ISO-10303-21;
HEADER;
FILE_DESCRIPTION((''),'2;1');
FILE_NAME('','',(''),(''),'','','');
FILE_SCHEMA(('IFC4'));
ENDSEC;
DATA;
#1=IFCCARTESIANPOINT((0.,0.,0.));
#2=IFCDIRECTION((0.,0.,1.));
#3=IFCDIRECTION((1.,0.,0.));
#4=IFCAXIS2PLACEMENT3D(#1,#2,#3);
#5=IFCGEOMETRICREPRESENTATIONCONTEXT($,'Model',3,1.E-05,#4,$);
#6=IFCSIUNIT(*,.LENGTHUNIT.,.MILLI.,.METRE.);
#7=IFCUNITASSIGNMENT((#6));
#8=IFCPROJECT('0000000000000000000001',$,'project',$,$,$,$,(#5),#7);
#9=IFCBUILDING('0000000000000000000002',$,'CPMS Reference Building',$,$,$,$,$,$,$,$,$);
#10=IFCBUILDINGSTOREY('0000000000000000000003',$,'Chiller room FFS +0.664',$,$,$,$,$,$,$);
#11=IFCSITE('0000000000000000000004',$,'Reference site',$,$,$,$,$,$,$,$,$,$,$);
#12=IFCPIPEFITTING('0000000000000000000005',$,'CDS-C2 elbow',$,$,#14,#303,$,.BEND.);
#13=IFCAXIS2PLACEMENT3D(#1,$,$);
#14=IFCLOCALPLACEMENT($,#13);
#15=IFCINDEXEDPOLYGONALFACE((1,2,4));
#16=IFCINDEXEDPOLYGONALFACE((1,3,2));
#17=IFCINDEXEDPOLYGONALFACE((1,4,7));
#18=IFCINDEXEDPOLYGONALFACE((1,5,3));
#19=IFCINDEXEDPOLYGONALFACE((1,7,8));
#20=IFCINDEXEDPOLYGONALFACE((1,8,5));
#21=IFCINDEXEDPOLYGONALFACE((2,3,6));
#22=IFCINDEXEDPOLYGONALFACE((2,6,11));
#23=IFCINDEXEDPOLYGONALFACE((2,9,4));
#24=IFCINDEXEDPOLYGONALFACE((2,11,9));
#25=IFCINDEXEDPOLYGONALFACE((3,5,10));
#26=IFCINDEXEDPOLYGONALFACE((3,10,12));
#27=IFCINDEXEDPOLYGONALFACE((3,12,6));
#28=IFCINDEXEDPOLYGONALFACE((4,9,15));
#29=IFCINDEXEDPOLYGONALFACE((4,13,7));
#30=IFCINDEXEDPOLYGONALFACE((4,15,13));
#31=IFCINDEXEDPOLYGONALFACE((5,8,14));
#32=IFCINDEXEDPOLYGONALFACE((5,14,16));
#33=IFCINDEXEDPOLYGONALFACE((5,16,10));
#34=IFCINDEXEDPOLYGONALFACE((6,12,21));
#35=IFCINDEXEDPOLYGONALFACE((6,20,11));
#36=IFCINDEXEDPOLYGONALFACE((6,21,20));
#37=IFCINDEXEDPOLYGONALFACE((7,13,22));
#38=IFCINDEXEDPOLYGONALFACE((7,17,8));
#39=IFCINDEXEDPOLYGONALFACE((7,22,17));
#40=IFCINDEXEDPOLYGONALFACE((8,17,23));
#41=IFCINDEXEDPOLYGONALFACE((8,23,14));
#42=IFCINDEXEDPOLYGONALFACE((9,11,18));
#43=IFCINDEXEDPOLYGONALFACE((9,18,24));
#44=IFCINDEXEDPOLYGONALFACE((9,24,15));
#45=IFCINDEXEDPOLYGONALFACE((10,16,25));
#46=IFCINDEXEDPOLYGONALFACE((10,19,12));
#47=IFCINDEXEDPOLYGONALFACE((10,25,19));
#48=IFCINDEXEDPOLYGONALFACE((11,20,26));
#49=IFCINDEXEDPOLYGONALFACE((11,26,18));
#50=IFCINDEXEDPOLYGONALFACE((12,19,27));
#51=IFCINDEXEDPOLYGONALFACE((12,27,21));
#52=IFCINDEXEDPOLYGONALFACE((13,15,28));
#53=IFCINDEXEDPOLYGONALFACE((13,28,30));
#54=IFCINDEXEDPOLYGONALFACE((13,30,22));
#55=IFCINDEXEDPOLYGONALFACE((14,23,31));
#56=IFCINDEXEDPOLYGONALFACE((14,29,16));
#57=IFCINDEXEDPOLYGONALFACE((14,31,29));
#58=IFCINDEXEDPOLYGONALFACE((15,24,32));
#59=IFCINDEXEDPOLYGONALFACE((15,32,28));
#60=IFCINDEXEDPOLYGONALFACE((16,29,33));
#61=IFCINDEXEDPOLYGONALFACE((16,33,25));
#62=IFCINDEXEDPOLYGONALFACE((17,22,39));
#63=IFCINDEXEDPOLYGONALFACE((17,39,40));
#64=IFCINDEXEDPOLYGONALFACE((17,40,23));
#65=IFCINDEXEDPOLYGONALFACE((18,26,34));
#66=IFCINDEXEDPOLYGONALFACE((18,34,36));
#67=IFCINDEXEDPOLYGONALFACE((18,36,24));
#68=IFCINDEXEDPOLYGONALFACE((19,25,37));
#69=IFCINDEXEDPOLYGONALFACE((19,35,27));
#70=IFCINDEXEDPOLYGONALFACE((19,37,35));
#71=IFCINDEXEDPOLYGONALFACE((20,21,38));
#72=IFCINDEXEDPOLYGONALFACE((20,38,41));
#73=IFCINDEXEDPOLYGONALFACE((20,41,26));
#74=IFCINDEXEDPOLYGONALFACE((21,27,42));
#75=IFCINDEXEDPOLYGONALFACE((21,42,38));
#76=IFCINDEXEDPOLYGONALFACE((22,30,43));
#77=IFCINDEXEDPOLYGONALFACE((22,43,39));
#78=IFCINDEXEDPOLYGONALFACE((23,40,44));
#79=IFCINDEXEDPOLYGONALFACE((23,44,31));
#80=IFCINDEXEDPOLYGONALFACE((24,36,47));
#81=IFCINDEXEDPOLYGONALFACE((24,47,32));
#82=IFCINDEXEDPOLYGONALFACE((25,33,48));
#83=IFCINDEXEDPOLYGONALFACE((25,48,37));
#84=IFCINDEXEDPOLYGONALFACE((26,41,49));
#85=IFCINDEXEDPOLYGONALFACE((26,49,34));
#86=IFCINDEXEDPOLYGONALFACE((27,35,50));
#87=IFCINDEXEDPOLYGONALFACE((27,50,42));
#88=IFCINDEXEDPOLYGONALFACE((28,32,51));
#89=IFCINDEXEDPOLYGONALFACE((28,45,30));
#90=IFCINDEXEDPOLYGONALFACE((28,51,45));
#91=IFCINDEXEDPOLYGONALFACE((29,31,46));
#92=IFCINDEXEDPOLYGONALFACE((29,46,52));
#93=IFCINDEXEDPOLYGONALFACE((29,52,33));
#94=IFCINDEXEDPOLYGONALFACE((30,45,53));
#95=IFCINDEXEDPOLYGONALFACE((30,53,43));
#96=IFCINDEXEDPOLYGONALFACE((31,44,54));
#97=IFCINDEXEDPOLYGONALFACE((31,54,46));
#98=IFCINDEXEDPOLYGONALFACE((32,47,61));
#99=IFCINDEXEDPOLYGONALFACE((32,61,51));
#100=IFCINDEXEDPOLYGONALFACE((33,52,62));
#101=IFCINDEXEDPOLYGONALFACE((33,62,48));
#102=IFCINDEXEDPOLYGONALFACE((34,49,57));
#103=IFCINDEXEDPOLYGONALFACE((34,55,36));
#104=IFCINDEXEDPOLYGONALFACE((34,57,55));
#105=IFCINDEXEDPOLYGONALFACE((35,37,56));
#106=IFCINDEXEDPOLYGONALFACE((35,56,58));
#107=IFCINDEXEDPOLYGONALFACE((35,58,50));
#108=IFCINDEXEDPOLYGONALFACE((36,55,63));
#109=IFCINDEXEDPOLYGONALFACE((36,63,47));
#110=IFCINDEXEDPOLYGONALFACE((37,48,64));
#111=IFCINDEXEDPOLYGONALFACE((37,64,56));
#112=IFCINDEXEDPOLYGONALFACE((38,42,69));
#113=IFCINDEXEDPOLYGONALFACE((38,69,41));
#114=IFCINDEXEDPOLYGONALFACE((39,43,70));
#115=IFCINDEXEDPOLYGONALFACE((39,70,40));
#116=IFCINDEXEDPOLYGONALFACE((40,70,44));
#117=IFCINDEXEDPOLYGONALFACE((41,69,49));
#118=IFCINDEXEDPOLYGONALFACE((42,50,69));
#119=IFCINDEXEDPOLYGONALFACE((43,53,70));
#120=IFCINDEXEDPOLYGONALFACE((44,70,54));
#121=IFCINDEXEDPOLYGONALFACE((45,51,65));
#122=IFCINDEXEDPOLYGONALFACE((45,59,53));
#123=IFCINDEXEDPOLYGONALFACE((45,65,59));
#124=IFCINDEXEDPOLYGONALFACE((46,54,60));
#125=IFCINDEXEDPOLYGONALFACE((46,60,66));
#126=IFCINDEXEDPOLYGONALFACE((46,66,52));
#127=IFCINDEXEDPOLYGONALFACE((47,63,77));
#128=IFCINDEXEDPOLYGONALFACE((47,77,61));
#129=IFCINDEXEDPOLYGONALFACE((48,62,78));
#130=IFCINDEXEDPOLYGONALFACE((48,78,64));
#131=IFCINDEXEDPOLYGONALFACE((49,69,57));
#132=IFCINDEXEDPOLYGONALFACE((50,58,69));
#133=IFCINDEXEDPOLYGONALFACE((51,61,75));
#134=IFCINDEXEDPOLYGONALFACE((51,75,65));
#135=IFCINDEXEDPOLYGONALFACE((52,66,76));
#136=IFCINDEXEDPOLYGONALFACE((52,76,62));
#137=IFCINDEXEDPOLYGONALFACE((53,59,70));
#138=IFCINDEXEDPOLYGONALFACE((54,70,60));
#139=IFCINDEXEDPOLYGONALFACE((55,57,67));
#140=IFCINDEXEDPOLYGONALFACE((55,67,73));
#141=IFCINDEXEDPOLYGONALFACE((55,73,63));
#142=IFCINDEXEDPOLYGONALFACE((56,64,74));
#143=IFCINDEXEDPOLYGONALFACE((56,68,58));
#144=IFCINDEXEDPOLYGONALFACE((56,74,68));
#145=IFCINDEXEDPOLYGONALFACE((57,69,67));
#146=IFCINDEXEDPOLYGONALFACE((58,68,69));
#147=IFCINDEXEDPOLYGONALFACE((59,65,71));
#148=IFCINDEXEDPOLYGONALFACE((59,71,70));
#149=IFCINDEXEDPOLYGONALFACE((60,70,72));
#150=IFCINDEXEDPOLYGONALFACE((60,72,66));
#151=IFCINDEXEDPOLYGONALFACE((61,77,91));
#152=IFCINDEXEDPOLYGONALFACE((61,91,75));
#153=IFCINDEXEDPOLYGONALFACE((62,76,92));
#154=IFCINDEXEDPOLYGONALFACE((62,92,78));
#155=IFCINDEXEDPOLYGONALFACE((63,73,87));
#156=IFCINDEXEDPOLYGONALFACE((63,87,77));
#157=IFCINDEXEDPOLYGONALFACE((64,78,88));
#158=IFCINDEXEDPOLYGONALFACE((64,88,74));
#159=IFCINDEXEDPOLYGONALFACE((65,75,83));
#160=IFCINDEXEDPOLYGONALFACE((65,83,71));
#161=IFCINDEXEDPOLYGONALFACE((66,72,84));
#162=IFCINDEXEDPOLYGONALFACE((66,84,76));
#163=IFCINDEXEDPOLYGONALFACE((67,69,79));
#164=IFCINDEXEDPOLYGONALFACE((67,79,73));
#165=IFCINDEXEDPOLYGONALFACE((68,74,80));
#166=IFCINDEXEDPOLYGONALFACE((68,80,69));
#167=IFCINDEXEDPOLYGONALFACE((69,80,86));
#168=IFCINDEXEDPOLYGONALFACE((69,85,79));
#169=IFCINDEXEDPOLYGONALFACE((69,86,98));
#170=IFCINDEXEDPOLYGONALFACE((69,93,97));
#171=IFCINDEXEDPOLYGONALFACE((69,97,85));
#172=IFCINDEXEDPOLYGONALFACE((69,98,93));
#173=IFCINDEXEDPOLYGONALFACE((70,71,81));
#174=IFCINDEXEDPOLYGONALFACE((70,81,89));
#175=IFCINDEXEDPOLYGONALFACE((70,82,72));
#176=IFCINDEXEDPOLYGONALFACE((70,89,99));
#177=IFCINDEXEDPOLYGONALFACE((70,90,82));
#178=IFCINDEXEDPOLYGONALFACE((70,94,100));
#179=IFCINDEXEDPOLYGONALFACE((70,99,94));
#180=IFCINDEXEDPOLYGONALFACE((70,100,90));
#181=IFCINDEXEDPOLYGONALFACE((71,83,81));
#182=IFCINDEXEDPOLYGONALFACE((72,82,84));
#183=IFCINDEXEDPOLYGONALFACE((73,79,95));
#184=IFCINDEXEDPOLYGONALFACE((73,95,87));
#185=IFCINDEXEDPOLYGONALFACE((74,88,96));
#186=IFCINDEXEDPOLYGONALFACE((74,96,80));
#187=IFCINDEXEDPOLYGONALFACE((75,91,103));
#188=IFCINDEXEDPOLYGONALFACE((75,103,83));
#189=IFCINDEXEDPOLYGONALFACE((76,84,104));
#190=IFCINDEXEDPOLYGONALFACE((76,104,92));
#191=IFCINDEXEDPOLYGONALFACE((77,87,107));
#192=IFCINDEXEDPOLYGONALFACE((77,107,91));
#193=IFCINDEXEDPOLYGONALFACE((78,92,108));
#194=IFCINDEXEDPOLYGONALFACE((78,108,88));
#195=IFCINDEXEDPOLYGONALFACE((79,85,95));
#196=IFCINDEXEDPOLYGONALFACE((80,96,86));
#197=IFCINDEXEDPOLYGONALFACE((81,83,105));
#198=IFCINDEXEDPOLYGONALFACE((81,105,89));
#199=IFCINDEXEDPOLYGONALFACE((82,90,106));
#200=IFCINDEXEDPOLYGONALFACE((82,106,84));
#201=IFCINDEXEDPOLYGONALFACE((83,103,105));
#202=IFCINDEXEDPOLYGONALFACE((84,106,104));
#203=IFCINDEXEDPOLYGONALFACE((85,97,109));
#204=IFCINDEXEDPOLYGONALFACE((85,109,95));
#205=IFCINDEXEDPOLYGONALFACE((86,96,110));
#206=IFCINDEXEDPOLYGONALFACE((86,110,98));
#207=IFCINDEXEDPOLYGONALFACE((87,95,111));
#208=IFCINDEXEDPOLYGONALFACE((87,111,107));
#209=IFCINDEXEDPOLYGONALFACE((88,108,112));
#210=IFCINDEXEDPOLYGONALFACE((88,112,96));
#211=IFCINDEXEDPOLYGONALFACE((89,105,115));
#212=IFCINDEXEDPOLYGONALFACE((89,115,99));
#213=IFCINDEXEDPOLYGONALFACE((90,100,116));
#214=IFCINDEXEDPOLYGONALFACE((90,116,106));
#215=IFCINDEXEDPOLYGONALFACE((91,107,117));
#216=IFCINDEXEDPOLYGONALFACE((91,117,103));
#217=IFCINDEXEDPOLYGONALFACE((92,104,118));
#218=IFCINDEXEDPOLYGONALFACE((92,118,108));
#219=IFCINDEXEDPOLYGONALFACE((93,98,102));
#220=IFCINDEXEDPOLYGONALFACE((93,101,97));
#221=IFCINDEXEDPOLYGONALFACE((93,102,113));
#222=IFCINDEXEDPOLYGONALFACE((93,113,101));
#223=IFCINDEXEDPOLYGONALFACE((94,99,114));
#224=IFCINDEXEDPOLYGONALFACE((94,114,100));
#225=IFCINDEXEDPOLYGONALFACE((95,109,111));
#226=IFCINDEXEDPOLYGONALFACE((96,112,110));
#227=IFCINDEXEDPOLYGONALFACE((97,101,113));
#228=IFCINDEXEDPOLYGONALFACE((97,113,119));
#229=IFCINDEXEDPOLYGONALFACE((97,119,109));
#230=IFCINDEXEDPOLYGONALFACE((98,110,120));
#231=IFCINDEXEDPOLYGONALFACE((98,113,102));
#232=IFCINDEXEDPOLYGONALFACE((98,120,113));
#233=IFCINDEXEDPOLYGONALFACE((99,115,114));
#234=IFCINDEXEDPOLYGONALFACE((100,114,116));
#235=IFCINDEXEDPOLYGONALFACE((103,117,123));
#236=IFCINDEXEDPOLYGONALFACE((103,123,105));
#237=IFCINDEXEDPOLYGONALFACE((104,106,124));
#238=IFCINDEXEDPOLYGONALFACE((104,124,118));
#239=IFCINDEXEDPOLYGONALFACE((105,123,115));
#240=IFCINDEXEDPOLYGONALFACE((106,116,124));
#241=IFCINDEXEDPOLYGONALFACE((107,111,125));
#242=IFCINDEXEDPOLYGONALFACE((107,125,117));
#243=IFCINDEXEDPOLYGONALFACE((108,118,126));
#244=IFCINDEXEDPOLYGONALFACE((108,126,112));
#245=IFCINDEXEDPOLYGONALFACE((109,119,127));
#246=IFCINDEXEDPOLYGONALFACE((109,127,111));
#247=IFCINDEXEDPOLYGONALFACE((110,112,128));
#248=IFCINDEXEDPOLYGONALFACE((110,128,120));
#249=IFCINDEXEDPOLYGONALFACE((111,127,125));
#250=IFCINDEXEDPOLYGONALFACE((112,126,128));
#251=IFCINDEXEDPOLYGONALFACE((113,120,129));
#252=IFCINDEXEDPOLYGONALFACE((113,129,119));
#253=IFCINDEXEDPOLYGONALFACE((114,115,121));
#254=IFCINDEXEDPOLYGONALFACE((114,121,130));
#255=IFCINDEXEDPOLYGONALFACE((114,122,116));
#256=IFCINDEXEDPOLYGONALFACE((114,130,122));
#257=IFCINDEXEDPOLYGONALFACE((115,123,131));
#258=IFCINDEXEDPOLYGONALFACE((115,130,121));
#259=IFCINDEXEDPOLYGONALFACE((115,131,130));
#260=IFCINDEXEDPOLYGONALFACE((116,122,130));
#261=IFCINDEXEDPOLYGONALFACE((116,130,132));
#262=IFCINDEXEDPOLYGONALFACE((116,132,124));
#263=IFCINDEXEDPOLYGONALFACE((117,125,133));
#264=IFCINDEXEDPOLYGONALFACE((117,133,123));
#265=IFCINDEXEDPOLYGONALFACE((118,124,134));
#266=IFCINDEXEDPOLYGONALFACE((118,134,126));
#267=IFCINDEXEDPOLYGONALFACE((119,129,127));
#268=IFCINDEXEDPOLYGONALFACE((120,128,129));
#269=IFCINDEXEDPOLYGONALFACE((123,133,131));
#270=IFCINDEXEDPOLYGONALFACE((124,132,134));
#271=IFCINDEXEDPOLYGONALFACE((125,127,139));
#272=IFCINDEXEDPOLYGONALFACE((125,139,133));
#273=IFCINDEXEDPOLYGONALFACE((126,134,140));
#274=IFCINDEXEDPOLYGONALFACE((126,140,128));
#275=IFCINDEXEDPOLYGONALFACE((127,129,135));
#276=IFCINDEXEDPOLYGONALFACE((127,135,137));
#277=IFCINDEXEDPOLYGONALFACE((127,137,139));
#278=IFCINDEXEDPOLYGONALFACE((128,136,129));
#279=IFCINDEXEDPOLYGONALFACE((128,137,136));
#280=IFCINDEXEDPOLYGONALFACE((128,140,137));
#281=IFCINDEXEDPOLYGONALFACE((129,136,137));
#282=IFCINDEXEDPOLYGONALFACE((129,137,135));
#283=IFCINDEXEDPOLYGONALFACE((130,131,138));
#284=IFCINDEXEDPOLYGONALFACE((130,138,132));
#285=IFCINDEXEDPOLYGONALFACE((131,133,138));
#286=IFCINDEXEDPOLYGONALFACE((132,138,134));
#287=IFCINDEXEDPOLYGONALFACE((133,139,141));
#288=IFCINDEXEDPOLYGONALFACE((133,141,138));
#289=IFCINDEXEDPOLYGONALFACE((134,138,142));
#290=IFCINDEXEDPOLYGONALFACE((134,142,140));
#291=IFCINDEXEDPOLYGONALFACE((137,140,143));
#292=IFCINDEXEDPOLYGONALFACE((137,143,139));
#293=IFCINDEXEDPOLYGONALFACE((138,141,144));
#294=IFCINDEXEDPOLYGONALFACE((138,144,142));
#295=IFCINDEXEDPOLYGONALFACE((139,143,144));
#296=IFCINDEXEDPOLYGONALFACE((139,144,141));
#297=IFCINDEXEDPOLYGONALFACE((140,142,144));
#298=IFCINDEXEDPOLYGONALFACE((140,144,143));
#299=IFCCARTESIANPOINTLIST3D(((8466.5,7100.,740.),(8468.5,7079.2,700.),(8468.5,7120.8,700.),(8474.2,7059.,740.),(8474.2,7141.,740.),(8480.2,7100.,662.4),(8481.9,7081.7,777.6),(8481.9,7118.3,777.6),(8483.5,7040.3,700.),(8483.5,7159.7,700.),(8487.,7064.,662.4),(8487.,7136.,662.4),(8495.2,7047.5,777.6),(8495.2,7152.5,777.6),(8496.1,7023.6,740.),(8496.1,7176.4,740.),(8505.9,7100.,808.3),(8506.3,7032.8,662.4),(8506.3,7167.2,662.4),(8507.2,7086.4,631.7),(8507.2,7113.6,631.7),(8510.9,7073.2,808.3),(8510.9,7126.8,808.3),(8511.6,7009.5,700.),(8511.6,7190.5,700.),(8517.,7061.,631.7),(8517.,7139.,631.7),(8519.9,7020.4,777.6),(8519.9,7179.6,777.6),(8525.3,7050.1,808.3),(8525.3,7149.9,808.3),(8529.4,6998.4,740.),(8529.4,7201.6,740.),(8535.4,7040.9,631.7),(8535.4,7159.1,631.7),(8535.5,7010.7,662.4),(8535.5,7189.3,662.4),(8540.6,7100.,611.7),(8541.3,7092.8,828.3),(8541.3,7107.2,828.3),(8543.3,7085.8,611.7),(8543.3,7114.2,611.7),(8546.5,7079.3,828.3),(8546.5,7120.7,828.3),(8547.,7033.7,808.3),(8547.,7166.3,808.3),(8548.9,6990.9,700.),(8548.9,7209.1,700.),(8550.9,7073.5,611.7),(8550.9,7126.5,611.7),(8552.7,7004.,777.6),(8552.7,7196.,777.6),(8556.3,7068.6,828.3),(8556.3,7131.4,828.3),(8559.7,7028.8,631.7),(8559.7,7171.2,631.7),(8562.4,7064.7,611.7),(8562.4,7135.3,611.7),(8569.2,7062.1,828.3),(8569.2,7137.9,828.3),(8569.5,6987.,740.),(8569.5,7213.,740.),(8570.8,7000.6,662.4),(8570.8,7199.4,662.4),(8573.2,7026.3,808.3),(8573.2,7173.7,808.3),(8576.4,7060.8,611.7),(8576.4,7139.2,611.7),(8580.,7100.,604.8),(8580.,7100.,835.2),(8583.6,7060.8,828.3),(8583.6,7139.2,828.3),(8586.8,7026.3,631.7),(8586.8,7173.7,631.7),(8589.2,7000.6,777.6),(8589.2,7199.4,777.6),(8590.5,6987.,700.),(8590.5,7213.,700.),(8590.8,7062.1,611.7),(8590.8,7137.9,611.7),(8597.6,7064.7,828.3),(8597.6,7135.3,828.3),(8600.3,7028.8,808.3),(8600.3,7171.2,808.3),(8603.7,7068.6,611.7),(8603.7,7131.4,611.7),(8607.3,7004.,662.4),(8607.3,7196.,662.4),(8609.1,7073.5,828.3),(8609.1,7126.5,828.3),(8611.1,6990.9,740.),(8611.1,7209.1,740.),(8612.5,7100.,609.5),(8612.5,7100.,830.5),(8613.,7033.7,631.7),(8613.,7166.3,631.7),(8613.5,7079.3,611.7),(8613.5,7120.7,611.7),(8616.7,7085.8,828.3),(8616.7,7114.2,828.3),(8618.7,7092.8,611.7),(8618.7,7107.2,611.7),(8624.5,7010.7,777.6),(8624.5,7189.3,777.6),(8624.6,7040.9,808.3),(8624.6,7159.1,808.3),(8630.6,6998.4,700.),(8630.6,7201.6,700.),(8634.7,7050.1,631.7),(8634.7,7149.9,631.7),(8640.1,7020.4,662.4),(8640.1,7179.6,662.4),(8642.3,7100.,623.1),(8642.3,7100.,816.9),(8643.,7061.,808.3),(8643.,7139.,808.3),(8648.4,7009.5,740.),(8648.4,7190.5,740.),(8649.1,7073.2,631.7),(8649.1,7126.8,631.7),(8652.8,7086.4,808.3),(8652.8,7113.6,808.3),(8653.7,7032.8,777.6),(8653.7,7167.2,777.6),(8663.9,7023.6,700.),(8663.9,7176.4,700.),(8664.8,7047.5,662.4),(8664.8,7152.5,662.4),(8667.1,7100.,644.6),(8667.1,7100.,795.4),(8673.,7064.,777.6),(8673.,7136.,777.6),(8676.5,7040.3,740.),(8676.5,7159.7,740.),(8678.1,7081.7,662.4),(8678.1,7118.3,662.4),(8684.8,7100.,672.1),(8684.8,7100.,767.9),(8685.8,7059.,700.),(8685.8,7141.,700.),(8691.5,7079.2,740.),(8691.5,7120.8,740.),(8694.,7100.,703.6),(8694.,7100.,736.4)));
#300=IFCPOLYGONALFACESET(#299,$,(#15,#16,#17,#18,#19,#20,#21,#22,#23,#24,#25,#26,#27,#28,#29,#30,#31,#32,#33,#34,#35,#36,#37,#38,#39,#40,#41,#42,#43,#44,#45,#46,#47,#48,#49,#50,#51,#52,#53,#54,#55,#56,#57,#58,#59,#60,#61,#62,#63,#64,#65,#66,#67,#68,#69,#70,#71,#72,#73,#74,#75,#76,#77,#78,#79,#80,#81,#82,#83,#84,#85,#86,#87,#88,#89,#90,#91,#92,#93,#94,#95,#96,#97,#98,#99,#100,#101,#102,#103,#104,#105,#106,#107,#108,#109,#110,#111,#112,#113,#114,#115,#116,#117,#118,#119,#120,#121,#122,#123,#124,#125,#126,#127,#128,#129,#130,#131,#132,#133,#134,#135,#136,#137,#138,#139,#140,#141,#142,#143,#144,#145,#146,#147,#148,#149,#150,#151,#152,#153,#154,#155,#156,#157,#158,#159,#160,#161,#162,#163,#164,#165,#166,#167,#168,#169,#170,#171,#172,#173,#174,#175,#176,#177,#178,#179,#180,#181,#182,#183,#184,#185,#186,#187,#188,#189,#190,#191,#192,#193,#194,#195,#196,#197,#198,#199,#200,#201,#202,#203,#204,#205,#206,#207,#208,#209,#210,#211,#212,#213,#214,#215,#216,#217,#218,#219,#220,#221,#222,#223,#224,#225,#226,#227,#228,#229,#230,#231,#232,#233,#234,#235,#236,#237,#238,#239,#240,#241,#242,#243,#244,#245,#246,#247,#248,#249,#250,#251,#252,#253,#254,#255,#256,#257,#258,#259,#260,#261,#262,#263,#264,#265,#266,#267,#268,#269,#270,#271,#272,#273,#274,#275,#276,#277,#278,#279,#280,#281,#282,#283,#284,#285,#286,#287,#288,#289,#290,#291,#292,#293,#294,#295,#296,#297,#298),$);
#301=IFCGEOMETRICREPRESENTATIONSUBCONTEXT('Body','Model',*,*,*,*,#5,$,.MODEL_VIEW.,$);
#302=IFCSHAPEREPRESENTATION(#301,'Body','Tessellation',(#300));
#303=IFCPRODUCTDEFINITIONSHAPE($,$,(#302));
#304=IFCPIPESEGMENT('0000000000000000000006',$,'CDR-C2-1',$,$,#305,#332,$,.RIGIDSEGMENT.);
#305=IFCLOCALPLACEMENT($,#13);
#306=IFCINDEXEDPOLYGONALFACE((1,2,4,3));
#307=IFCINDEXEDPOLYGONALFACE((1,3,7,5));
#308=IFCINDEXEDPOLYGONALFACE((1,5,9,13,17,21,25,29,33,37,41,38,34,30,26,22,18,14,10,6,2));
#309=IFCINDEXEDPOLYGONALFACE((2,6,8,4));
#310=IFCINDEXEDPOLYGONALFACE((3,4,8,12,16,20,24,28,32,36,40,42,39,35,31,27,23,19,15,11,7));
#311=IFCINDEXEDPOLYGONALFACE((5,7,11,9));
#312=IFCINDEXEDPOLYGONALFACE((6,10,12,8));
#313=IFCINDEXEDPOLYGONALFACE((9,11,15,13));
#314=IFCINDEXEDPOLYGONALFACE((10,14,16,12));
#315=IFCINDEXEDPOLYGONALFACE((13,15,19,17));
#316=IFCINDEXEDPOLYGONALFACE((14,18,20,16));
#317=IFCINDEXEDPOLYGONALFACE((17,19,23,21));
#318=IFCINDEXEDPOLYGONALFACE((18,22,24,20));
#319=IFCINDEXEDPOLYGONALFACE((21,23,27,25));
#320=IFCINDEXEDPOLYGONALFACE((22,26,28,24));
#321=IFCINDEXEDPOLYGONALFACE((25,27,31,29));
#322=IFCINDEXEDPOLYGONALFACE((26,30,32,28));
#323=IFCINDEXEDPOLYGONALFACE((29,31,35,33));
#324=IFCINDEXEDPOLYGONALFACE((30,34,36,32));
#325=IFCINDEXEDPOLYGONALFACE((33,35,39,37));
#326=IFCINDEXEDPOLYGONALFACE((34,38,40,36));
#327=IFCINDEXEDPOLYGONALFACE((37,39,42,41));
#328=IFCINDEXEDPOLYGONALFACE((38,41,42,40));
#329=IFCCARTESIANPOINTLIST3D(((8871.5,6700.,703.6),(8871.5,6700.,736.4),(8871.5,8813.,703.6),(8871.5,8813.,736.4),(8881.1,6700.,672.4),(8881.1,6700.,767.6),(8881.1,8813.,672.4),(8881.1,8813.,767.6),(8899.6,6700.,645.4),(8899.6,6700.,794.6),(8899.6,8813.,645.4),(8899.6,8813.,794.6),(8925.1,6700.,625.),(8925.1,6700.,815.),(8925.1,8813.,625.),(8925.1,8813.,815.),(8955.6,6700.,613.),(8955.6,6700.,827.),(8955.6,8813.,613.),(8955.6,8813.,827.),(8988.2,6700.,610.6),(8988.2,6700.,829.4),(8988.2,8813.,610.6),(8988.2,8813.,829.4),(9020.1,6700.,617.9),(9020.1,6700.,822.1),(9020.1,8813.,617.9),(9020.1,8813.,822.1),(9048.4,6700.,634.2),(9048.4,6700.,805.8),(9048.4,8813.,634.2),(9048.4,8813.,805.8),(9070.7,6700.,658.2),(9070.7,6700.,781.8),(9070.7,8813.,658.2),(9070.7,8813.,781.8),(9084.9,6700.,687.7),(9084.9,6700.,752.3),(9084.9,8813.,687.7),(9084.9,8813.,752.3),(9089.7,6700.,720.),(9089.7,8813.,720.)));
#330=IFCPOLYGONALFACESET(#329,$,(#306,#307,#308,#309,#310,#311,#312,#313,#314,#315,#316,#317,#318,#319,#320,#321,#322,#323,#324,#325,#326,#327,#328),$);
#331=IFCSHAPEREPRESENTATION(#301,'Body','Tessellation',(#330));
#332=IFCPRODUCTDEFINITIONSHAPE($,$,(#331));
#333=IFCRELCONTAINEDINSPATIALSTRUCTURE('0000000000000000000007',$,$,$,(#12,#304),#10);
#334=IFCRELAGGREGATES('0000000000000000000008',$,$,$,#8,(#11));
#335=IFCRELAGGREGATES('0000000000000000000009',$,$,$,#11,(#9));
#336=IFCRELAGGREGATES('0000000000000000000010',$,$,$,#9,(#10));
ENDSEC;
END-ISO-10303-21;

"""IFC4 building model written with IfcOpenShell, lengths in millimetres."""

from ifc_helpers import new_model, entity, si_unit, frame, origin_with_axes, origin_2d, place, context, subcontext, project, spatial, circle_curve, outline, extrude, element, save


model = new_model("IFC4")

# Units and contexts
model_context = context("Model", 3, precision=1e-05, world=origin_with_axes())
body_context = subcontext(model_context, "Body", "Model", "MODEL_VIEW")
ifc_project = project(units=[si_unit("LENGTHUNIT", "METRE", prefix="MILLI")], contexts=[model_context])

# Site, building, storey
site = spatial("IfcSite", under=ifc_project, Name="Reference site")
building = spatial("IfcBuilding", under=site, Name="CPMS Reference Building")
storey = spatial("IfcBuildingStorey", under=building, Name="Chiller room FFS +0.664")

# Pipe fitting
pipe_fitting_1_placement = place(None, origin_with_axes())
element("IfcPipeFitting", 1, at=pipe_fitting_1_placement, inside=storey, Name="CDS-C2 elbow", PredefinedType="BEND", context=body_context, shape_type="CSG", body=[
    entity("IfcSphere", entity("IfcAxis2Placement3D", entity("IfcCartesianPoint", [8580.0, 7100.0, 720.0]), entity("IfcDirection", [0.0, 0.0, 1.0]), entity("IfcDirection", [1.0, 0.0, 0.0])), 115.2),
])

# Pipe segment
pipe_segment_1_placement = place(None, origin_with_axes())
element("IfcPipeSegment", 2, at=pipe_segment_1_placement, inside=storey, Name="CDR-C2-1", PredefinedType="RIGIDSEGMENT", context=body_context, shape_type="SweptSolid", body=[
    extrude(outline(circle_curve(origin_2d(), 109.7)), frame((8980.0, 8813.0, 720.0), z_axis=(0.0, -1.0, 0.0), x_axis=(1.0, 0.0, 0.0)), (0.0, 0.0, 1.0), 2113.0),
])

save(model, "model.ifc")
